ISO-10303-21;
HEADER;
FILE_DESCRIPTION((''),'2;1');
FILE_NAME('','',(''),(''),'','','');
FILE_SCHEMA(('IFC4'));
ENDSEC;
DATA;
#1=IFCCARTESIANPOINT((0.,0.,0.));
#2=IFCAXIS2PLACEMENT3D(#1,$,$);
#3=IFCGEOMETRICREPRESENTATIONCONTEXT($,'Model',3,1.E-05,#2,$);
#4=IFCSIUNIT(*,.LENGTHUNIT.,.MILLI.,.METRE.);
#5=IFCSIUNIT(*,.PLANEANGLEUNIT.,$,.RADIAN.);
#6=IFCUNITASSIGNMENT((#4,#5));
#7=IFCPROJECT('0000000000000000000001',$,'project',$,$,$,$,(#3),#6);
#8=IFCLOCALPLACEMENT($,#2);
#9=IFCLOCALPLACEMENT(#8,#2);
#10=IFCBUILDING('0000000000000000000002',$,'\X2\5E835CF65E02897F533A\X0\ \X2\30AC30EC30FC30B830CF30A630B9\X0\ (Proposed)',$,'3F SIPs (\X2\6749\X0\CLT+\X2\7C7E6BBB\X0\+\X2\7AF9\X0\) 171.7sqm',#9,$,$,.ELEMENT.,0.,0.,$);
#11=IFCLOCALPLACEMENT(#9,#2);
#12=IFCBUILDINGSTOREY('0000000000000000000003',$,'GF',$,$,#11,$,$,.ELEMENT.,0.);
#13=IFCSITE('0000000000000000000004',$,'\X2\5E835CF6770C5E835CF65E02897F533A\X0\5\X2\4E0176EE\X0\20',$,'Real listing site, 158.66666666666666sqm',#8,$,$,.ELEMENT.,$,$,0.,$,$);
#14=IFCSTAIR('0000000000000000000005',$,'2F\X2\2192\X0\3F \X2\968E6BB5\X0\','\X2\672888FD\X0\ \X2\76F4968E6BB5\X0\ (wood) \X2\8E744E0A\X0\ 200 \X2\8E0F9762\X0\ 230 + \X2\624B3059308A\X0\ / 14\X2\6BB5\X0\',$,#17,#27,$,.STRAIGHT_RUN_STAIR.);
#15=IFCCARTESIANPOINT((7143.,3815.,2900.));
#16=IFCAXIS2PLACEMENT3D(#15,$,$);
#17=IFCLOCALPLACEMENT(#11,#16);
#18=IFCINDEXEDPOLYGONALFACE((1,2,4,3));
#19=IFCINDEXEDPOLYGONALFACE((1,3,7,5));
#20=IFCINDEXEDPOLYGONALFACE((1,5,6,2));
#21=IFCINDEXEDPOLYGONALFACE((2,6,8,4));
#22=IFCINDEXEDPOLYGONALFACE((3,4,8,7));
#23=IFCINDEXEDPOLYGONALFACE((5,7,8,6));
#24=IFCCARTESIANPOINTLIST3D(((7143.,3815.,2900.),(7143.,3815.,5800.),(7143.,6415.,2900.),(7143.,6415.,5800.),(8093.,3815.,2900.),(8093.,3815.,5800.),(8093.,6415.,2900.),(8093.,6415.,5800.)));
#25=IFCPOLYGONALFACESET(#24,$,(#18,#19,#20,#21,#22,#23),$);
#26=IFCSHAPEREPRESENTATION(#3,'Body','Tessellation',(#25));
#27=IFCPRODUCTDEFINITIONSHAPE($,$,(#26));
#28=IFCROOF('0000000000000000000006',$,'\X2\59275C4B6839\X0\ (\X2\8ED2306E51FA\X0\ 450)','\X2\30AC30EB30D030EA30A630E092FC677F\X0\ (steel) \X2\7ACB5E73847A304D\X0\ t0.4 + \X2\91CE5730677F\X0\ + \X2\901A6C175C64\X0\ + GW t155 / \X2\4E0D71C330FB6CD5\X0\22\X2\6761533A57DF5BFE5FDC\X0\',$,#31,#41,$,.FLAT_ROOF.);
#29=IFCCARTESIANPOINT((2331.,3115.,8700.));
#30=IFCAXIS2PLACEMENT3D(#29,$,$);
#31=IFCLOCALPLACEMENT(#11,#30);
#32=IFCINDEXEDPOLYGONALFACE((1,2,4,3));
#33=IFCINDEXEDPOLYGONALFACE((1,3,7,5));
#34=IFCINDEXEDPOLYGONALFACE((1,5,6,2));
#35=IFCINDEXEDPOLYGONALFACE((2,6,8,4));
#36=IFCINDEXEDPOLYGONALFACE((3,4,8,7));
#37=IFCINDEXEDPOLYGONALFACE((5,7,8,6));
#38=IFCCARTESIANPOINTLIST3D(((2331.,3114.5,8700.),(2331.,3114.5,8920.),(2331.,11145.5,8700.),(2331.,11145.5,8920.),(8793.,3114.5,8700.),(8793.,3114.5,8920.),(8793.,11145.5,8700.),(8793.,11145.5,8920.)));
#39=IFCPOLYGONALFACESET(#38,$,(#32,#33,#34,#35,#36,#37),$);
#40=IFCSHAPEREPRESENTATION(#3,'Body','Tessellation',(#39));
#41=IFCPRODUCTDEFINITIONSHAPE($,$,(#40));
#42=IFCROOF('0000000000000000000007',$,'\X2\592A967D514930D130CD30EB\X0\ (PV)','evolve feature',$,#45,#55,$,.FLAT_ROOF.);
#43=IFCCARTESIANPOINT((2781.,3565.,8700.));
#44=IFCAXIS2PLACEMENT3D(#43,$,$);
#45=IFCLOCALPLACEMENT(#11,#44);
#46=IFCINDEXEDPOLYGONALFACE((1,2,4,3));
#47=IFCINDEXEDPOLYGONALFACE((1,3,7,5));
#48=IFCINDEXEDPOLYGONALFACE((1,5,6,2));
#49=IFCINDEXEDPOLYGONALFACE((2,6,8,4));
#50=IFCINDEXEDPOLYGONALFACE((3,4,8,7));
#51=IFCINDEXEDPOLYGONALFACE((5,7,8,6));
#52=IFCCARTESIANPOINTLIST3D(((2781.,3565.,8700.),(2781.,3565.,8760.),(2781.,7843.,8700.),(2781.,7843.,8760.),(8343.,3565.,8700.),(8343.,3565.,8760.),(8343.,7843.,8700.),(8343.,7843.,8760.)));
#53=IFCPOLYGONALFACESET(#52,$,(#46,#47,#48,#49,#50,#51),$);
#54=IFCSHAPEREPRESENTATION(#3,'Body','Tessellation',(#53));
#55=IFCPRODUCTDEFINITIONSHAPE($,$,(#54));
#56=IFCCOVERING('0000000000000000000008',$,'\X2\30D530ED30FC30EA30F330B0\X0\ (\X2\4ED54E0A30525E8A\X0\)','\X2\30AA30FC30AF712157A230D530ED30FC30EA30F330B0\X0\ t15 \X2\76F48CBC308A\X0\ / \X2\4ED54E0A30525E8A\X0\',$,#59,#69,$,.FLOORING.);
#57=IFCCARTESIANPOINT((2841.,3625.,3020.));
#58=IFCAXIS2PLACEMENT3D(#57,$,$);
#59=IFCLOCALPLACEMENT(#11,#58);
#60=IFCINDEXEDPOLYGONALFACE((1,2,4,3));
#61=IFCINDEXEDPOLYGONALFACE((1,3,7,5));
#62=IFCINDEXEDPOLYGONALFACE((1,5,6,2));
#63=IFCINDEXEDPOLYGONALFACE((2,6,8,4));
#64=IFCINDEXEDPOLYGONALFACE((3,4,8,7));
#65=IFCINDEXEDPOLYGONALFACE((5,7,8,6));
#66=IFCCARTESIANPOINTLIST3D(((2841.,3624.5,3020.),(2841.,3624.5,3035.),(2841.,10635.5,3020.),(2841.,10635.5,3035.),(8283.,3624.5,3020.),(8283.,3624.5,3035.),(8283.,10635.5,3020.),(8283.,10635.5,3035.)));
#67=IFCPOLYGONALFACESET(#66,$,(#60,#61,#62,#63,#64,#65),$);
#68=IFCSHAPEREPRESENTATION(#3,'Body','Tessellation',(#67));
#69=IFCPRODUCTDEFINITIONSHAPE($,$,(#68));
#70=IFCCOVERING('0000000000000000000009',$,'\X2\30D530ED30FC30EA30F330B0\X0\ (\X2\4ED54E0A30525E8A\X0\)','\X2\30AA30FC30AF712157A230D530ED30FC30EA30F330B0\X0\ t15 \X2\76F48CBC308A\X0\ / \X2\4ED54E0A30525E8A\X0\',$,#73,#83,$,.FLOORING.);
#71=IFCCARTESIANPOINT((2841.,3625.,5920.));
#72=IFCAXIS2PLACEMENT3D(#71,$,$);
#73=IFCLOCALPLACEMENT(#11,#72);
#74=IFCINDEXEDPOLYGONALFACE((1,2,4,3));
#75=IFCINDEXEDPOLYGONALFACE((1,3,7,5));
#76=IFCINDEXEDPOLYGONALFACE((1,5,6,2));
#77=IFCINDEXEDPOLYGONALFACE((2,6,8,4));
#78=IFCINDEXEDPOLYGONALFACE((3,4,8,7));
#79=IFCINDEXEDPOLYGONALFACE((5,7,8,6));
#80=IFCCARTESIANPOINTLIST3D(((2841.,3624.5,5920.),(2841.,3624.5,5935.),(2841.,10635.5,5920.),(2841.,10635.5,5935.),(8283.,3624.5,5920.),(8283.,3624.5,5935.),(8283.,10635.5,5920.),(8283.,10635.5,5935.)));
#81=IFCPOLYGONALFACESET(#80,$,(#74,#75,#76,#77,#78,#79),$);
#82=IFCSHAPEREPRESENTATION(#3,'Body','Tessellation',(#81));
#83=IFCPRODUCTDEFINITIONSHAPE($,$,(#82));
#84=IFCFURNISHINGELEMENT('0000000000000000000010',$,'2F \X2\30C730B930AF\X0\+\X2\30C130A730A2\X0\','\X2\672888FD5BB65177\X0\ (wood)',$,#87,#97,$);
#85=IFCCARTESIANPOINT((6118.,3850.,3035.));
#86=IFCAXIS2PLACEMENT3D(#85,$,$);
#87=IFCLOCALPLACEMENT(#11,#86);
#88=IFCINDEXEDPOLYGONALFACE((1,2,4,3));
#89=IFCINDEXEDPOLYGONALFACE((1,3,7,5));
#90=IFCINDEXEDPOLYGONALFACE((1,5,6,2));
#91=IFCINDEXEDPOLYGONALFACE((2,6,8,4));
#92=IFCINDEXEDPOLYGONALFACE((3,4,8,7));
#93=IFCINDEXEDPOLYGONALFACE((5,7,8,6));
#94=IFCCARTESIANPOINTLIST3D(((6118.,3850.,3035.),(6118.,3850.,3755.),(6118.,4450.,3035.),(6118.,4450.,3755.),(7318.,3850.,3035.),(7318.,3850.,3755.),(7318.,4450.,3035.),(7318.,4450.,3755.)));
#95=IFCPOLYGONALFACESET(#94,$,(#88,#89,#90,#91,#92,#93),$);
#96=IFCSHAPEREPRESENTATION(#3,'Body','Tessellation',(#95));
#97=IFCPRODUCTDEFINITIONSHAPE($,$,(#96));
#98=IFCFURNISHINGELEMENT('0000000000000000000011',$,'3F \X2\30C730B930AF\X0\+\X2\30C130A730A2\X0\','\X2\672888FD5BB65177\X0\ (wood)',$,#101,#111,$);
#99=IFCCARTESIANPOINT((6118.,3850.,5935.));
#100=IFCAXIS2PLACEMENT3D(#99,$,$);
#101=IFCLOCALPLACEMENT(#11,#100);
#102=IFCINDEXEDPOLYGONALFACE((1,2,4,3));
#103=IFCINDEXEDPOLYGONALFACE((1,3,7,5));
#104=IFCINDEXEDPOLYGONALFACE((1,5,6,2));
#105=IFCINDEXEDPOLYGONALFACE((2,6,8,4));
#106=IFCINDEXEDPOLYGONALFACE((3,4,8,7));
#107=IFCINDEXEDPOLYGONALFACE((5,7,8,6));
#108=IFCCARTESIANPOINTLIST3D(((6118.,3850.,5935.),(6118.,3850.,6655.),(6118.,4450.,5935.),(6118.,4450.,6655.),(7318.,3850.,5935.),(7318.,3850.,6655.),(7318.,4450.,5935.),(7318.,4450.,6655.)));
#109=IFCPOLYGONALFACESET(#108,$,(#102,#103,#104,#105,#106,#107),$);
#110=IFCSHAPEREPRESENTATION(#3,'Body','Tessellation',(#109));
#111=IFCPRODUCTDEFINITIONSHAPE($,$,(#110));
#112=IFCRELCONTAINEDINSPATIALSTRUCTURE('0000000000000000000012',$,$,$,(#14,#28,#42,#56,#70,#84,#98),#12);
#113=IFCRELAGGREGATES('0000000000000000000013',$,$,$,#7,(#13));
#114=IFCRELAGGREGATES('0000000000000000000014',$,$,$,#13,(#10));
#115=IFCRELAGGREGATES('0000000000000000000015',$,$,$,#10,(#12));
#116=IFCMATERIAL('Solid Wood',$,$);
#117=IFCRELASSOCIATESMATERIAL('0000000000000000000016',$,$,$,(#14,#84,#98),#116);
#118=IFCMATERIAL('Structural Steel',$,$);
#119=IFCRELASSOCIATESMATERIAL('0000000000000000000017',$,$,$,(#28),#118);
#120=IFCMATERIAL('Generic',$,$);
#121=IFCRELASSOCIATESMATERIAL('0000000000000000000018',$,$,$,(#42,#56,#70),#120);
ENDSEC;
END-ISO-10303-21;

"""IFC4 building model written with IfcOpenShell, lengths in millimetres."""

from ifc_helpers import new_model, si_unit, frame, frame_2d, origin, place, context, project, spatial, rectangle, extrude, material, element, save


model = new_model("IFC4")

# Units and contexts
model_context = context("Model", 3, precision=1e-05, world=origin())
ifc_project = project(units=[si_unit("LENGTHUNIT", "METRE", prefix="MILLI"), si_unit("PLANEANGLEUNIT", "RADIAN")], contexts=[model_context])

# Site, building, storey
site_placement = place(None, origin())
site = spatial("IfcSite", under=ifc_project, at=site_placement, Name="広島県広島市西区5丁目20", ObjectType="Real listing site, 158.66666666666666sqm", CompositionType="ELEMENT", RefElevation=0.0)
building_placement = place(site_placement, origin())
building = spatial("IfcBuilding", under=site, at=building_placement, Name="広島市西区 ガレージハウス (Proposed)", ObjectType="3F SIPs (杉CLT+籾殻+竹) 171.7sqm", CompositionType="ELEMENT", ElevationOfRefHeight=0.0, ElevationOfTerrain=0.0)
storey_placement = place(building_placement, origin())
storey = spatial("IfcBuildingStorey", under=building, at=storey_placement, Name="GF", CompositionType="ELEMENT", Elevation=0.0)

# Shared definitions
ifc_material_1 = material(Name="Solid Wood")

# Shared definitions
ifc_material_2 = material(Name="Generic")

# Stair
stair_placement = place(storey_placement, frame((7143.0, 3815.0, 2900.0)))
element("IfcStair", 1, at=stair_placement, inside=storey, material=ifc_material_1, Name="2F→3F 階段", Description="木製 直階段 (wood) 蹴上 200 踏面 230 + 手すり / 14段", PredefinedType="STRAIGHT_RUN_STAIR", context=model_context, shape_type="SweptSolid", body=[
    extrude(rectangle(XDim=950.0, YDim=2600.0, at=frame_2d((475.0, 1300.0))), frame((7143.0, 3815.0, 2900.0)), (0.0, 0.0, 1.0), 2900.0),
])

# Roofs
ifc_material_3 = material(Name="Structural Steel")
roof_1_placement = place(storey_placement, frame((2331.0, 3115.0, 8700.0)))
element("IfcRoof", 2, at=roof_1_placement, inside=storey, material=ifc_material_3, Name="大屋根 (軒の出 450)", Description="ガルバリウム鋼板 (steel) 立平葺き t0.4 + 野地板 + 通気層 + GW t155 / 不燃・法22条区域対応", PredefinedType="FLAT_ROOF", context=model_context, shape_type="SweptSolid", body=[
    extrude(rectangle(XDim=6462.0, YDim=8031.0, at=frame_2d((3231.0, 4015.0))), frame((2331.0, 3115.0, 8700.0)), (0.0, 0.0, 1.0), 220.0),
])
roof_2_placement = place(storey_placement, frame((2781.0, 3565.0, 8700.0)))
element("IfcRoof", 3, at=roof_2_placement, inside=storey, material=ifc_material_2, Name="太陽光パネル (PV)", Description="evolve feature", PredefinedType="FLAT_ROOF", context=model_context, shape_type="SweptSolid", body=[
    extrude(rectangle(XDim=5562.0, YDim=4278.0, at=frame_2d((2781.0, 2139.0))), frame((2781.0, 3565.0, 8700.0)), (0.0, 0.0, 1.0), 60.0),
])

# Coverings
covering_1_placement = place(storey_placement, frame((2841.0, 3625.0, 3020.0)))
element("IfcCovering", 4, at=covering_1_placement, inside=storey, material=ifc_material_2, Name="フローリング (仕上げ床)", Description="オーク無垢フローリング t15 直貼り / 仕上げ床", PredefinedType="FLOORING", context=model_context, shape_type="SweptSolid", body=[
    extrude(rectangle(XDim=5442.0, YDim=7011.0, at=frame_2d((2721.0, 3505.0))), frame((2841.0, 3625.0, 3020.0)), (0.0, 0.0, 1.0), 15.0),
])
covering_2_placement = place(storey_placement, frame((2841.0, 3625.0, 5920.0)))
element("IfcCovering", 5, at=covering_2_placement, inside=storey, material=ifc_material_2, Name="フローリング (仕上げ床)", Description="オーク無垢フローリング t15 直貼り / 仕上げ床", PredefinedType="FLOORING", context=model_context, shape_type="SweptSolid", body=[
    extrude(rectangle(XDim=5442.0, YDim=7011.0, at=frame_2d((2721.0, 3505.0))), frame((2841.0, 3625.0, 5920.0)), (0.0, 0.0, 1.0), 15.0),
])

# Furnishing elements
furnishing_1_placement = place(storey_placement, frame((6118.0, 3850.0, 3035.0)))
element("IfcFurnishingElement", 6, at=furnishing_1_placement, inside=storey, material=ifc_material_1, Name="2F デスク+チェア", Description="木製家具 (wood)", context=model_context, shape_type="SweptSolid", body=[
    extrude(rectangle(XDim=1200.0, YDim=600.0, at=frame_2d((600.0, 300.0))), frame((6118.0, 3850.0, 3035.0)), (0.0, 0.0, 1.0), 720.0),
])
furnishing_2_placement = place(storey_placement, frame((6118.0, 3850.0, 5935.0)))
element("IfcFurnishingElement", 7, at=furnishing_2_placement, inside=storey, material=ifc_material_1, Name="3F デスク+チェア", Description="木製家具 (wood)", context=model_context, shape_type="SweptSolid", body=[
    extrude(rectangle(XDim=1200.0, YDim=600.0, at=frame_2d((600.0, 300.0))), frame((6118.0, 3850.0, 5935.0)), (0.0, 0.0, 1.0), 720.0),
])

save(model, "model.ifc")
